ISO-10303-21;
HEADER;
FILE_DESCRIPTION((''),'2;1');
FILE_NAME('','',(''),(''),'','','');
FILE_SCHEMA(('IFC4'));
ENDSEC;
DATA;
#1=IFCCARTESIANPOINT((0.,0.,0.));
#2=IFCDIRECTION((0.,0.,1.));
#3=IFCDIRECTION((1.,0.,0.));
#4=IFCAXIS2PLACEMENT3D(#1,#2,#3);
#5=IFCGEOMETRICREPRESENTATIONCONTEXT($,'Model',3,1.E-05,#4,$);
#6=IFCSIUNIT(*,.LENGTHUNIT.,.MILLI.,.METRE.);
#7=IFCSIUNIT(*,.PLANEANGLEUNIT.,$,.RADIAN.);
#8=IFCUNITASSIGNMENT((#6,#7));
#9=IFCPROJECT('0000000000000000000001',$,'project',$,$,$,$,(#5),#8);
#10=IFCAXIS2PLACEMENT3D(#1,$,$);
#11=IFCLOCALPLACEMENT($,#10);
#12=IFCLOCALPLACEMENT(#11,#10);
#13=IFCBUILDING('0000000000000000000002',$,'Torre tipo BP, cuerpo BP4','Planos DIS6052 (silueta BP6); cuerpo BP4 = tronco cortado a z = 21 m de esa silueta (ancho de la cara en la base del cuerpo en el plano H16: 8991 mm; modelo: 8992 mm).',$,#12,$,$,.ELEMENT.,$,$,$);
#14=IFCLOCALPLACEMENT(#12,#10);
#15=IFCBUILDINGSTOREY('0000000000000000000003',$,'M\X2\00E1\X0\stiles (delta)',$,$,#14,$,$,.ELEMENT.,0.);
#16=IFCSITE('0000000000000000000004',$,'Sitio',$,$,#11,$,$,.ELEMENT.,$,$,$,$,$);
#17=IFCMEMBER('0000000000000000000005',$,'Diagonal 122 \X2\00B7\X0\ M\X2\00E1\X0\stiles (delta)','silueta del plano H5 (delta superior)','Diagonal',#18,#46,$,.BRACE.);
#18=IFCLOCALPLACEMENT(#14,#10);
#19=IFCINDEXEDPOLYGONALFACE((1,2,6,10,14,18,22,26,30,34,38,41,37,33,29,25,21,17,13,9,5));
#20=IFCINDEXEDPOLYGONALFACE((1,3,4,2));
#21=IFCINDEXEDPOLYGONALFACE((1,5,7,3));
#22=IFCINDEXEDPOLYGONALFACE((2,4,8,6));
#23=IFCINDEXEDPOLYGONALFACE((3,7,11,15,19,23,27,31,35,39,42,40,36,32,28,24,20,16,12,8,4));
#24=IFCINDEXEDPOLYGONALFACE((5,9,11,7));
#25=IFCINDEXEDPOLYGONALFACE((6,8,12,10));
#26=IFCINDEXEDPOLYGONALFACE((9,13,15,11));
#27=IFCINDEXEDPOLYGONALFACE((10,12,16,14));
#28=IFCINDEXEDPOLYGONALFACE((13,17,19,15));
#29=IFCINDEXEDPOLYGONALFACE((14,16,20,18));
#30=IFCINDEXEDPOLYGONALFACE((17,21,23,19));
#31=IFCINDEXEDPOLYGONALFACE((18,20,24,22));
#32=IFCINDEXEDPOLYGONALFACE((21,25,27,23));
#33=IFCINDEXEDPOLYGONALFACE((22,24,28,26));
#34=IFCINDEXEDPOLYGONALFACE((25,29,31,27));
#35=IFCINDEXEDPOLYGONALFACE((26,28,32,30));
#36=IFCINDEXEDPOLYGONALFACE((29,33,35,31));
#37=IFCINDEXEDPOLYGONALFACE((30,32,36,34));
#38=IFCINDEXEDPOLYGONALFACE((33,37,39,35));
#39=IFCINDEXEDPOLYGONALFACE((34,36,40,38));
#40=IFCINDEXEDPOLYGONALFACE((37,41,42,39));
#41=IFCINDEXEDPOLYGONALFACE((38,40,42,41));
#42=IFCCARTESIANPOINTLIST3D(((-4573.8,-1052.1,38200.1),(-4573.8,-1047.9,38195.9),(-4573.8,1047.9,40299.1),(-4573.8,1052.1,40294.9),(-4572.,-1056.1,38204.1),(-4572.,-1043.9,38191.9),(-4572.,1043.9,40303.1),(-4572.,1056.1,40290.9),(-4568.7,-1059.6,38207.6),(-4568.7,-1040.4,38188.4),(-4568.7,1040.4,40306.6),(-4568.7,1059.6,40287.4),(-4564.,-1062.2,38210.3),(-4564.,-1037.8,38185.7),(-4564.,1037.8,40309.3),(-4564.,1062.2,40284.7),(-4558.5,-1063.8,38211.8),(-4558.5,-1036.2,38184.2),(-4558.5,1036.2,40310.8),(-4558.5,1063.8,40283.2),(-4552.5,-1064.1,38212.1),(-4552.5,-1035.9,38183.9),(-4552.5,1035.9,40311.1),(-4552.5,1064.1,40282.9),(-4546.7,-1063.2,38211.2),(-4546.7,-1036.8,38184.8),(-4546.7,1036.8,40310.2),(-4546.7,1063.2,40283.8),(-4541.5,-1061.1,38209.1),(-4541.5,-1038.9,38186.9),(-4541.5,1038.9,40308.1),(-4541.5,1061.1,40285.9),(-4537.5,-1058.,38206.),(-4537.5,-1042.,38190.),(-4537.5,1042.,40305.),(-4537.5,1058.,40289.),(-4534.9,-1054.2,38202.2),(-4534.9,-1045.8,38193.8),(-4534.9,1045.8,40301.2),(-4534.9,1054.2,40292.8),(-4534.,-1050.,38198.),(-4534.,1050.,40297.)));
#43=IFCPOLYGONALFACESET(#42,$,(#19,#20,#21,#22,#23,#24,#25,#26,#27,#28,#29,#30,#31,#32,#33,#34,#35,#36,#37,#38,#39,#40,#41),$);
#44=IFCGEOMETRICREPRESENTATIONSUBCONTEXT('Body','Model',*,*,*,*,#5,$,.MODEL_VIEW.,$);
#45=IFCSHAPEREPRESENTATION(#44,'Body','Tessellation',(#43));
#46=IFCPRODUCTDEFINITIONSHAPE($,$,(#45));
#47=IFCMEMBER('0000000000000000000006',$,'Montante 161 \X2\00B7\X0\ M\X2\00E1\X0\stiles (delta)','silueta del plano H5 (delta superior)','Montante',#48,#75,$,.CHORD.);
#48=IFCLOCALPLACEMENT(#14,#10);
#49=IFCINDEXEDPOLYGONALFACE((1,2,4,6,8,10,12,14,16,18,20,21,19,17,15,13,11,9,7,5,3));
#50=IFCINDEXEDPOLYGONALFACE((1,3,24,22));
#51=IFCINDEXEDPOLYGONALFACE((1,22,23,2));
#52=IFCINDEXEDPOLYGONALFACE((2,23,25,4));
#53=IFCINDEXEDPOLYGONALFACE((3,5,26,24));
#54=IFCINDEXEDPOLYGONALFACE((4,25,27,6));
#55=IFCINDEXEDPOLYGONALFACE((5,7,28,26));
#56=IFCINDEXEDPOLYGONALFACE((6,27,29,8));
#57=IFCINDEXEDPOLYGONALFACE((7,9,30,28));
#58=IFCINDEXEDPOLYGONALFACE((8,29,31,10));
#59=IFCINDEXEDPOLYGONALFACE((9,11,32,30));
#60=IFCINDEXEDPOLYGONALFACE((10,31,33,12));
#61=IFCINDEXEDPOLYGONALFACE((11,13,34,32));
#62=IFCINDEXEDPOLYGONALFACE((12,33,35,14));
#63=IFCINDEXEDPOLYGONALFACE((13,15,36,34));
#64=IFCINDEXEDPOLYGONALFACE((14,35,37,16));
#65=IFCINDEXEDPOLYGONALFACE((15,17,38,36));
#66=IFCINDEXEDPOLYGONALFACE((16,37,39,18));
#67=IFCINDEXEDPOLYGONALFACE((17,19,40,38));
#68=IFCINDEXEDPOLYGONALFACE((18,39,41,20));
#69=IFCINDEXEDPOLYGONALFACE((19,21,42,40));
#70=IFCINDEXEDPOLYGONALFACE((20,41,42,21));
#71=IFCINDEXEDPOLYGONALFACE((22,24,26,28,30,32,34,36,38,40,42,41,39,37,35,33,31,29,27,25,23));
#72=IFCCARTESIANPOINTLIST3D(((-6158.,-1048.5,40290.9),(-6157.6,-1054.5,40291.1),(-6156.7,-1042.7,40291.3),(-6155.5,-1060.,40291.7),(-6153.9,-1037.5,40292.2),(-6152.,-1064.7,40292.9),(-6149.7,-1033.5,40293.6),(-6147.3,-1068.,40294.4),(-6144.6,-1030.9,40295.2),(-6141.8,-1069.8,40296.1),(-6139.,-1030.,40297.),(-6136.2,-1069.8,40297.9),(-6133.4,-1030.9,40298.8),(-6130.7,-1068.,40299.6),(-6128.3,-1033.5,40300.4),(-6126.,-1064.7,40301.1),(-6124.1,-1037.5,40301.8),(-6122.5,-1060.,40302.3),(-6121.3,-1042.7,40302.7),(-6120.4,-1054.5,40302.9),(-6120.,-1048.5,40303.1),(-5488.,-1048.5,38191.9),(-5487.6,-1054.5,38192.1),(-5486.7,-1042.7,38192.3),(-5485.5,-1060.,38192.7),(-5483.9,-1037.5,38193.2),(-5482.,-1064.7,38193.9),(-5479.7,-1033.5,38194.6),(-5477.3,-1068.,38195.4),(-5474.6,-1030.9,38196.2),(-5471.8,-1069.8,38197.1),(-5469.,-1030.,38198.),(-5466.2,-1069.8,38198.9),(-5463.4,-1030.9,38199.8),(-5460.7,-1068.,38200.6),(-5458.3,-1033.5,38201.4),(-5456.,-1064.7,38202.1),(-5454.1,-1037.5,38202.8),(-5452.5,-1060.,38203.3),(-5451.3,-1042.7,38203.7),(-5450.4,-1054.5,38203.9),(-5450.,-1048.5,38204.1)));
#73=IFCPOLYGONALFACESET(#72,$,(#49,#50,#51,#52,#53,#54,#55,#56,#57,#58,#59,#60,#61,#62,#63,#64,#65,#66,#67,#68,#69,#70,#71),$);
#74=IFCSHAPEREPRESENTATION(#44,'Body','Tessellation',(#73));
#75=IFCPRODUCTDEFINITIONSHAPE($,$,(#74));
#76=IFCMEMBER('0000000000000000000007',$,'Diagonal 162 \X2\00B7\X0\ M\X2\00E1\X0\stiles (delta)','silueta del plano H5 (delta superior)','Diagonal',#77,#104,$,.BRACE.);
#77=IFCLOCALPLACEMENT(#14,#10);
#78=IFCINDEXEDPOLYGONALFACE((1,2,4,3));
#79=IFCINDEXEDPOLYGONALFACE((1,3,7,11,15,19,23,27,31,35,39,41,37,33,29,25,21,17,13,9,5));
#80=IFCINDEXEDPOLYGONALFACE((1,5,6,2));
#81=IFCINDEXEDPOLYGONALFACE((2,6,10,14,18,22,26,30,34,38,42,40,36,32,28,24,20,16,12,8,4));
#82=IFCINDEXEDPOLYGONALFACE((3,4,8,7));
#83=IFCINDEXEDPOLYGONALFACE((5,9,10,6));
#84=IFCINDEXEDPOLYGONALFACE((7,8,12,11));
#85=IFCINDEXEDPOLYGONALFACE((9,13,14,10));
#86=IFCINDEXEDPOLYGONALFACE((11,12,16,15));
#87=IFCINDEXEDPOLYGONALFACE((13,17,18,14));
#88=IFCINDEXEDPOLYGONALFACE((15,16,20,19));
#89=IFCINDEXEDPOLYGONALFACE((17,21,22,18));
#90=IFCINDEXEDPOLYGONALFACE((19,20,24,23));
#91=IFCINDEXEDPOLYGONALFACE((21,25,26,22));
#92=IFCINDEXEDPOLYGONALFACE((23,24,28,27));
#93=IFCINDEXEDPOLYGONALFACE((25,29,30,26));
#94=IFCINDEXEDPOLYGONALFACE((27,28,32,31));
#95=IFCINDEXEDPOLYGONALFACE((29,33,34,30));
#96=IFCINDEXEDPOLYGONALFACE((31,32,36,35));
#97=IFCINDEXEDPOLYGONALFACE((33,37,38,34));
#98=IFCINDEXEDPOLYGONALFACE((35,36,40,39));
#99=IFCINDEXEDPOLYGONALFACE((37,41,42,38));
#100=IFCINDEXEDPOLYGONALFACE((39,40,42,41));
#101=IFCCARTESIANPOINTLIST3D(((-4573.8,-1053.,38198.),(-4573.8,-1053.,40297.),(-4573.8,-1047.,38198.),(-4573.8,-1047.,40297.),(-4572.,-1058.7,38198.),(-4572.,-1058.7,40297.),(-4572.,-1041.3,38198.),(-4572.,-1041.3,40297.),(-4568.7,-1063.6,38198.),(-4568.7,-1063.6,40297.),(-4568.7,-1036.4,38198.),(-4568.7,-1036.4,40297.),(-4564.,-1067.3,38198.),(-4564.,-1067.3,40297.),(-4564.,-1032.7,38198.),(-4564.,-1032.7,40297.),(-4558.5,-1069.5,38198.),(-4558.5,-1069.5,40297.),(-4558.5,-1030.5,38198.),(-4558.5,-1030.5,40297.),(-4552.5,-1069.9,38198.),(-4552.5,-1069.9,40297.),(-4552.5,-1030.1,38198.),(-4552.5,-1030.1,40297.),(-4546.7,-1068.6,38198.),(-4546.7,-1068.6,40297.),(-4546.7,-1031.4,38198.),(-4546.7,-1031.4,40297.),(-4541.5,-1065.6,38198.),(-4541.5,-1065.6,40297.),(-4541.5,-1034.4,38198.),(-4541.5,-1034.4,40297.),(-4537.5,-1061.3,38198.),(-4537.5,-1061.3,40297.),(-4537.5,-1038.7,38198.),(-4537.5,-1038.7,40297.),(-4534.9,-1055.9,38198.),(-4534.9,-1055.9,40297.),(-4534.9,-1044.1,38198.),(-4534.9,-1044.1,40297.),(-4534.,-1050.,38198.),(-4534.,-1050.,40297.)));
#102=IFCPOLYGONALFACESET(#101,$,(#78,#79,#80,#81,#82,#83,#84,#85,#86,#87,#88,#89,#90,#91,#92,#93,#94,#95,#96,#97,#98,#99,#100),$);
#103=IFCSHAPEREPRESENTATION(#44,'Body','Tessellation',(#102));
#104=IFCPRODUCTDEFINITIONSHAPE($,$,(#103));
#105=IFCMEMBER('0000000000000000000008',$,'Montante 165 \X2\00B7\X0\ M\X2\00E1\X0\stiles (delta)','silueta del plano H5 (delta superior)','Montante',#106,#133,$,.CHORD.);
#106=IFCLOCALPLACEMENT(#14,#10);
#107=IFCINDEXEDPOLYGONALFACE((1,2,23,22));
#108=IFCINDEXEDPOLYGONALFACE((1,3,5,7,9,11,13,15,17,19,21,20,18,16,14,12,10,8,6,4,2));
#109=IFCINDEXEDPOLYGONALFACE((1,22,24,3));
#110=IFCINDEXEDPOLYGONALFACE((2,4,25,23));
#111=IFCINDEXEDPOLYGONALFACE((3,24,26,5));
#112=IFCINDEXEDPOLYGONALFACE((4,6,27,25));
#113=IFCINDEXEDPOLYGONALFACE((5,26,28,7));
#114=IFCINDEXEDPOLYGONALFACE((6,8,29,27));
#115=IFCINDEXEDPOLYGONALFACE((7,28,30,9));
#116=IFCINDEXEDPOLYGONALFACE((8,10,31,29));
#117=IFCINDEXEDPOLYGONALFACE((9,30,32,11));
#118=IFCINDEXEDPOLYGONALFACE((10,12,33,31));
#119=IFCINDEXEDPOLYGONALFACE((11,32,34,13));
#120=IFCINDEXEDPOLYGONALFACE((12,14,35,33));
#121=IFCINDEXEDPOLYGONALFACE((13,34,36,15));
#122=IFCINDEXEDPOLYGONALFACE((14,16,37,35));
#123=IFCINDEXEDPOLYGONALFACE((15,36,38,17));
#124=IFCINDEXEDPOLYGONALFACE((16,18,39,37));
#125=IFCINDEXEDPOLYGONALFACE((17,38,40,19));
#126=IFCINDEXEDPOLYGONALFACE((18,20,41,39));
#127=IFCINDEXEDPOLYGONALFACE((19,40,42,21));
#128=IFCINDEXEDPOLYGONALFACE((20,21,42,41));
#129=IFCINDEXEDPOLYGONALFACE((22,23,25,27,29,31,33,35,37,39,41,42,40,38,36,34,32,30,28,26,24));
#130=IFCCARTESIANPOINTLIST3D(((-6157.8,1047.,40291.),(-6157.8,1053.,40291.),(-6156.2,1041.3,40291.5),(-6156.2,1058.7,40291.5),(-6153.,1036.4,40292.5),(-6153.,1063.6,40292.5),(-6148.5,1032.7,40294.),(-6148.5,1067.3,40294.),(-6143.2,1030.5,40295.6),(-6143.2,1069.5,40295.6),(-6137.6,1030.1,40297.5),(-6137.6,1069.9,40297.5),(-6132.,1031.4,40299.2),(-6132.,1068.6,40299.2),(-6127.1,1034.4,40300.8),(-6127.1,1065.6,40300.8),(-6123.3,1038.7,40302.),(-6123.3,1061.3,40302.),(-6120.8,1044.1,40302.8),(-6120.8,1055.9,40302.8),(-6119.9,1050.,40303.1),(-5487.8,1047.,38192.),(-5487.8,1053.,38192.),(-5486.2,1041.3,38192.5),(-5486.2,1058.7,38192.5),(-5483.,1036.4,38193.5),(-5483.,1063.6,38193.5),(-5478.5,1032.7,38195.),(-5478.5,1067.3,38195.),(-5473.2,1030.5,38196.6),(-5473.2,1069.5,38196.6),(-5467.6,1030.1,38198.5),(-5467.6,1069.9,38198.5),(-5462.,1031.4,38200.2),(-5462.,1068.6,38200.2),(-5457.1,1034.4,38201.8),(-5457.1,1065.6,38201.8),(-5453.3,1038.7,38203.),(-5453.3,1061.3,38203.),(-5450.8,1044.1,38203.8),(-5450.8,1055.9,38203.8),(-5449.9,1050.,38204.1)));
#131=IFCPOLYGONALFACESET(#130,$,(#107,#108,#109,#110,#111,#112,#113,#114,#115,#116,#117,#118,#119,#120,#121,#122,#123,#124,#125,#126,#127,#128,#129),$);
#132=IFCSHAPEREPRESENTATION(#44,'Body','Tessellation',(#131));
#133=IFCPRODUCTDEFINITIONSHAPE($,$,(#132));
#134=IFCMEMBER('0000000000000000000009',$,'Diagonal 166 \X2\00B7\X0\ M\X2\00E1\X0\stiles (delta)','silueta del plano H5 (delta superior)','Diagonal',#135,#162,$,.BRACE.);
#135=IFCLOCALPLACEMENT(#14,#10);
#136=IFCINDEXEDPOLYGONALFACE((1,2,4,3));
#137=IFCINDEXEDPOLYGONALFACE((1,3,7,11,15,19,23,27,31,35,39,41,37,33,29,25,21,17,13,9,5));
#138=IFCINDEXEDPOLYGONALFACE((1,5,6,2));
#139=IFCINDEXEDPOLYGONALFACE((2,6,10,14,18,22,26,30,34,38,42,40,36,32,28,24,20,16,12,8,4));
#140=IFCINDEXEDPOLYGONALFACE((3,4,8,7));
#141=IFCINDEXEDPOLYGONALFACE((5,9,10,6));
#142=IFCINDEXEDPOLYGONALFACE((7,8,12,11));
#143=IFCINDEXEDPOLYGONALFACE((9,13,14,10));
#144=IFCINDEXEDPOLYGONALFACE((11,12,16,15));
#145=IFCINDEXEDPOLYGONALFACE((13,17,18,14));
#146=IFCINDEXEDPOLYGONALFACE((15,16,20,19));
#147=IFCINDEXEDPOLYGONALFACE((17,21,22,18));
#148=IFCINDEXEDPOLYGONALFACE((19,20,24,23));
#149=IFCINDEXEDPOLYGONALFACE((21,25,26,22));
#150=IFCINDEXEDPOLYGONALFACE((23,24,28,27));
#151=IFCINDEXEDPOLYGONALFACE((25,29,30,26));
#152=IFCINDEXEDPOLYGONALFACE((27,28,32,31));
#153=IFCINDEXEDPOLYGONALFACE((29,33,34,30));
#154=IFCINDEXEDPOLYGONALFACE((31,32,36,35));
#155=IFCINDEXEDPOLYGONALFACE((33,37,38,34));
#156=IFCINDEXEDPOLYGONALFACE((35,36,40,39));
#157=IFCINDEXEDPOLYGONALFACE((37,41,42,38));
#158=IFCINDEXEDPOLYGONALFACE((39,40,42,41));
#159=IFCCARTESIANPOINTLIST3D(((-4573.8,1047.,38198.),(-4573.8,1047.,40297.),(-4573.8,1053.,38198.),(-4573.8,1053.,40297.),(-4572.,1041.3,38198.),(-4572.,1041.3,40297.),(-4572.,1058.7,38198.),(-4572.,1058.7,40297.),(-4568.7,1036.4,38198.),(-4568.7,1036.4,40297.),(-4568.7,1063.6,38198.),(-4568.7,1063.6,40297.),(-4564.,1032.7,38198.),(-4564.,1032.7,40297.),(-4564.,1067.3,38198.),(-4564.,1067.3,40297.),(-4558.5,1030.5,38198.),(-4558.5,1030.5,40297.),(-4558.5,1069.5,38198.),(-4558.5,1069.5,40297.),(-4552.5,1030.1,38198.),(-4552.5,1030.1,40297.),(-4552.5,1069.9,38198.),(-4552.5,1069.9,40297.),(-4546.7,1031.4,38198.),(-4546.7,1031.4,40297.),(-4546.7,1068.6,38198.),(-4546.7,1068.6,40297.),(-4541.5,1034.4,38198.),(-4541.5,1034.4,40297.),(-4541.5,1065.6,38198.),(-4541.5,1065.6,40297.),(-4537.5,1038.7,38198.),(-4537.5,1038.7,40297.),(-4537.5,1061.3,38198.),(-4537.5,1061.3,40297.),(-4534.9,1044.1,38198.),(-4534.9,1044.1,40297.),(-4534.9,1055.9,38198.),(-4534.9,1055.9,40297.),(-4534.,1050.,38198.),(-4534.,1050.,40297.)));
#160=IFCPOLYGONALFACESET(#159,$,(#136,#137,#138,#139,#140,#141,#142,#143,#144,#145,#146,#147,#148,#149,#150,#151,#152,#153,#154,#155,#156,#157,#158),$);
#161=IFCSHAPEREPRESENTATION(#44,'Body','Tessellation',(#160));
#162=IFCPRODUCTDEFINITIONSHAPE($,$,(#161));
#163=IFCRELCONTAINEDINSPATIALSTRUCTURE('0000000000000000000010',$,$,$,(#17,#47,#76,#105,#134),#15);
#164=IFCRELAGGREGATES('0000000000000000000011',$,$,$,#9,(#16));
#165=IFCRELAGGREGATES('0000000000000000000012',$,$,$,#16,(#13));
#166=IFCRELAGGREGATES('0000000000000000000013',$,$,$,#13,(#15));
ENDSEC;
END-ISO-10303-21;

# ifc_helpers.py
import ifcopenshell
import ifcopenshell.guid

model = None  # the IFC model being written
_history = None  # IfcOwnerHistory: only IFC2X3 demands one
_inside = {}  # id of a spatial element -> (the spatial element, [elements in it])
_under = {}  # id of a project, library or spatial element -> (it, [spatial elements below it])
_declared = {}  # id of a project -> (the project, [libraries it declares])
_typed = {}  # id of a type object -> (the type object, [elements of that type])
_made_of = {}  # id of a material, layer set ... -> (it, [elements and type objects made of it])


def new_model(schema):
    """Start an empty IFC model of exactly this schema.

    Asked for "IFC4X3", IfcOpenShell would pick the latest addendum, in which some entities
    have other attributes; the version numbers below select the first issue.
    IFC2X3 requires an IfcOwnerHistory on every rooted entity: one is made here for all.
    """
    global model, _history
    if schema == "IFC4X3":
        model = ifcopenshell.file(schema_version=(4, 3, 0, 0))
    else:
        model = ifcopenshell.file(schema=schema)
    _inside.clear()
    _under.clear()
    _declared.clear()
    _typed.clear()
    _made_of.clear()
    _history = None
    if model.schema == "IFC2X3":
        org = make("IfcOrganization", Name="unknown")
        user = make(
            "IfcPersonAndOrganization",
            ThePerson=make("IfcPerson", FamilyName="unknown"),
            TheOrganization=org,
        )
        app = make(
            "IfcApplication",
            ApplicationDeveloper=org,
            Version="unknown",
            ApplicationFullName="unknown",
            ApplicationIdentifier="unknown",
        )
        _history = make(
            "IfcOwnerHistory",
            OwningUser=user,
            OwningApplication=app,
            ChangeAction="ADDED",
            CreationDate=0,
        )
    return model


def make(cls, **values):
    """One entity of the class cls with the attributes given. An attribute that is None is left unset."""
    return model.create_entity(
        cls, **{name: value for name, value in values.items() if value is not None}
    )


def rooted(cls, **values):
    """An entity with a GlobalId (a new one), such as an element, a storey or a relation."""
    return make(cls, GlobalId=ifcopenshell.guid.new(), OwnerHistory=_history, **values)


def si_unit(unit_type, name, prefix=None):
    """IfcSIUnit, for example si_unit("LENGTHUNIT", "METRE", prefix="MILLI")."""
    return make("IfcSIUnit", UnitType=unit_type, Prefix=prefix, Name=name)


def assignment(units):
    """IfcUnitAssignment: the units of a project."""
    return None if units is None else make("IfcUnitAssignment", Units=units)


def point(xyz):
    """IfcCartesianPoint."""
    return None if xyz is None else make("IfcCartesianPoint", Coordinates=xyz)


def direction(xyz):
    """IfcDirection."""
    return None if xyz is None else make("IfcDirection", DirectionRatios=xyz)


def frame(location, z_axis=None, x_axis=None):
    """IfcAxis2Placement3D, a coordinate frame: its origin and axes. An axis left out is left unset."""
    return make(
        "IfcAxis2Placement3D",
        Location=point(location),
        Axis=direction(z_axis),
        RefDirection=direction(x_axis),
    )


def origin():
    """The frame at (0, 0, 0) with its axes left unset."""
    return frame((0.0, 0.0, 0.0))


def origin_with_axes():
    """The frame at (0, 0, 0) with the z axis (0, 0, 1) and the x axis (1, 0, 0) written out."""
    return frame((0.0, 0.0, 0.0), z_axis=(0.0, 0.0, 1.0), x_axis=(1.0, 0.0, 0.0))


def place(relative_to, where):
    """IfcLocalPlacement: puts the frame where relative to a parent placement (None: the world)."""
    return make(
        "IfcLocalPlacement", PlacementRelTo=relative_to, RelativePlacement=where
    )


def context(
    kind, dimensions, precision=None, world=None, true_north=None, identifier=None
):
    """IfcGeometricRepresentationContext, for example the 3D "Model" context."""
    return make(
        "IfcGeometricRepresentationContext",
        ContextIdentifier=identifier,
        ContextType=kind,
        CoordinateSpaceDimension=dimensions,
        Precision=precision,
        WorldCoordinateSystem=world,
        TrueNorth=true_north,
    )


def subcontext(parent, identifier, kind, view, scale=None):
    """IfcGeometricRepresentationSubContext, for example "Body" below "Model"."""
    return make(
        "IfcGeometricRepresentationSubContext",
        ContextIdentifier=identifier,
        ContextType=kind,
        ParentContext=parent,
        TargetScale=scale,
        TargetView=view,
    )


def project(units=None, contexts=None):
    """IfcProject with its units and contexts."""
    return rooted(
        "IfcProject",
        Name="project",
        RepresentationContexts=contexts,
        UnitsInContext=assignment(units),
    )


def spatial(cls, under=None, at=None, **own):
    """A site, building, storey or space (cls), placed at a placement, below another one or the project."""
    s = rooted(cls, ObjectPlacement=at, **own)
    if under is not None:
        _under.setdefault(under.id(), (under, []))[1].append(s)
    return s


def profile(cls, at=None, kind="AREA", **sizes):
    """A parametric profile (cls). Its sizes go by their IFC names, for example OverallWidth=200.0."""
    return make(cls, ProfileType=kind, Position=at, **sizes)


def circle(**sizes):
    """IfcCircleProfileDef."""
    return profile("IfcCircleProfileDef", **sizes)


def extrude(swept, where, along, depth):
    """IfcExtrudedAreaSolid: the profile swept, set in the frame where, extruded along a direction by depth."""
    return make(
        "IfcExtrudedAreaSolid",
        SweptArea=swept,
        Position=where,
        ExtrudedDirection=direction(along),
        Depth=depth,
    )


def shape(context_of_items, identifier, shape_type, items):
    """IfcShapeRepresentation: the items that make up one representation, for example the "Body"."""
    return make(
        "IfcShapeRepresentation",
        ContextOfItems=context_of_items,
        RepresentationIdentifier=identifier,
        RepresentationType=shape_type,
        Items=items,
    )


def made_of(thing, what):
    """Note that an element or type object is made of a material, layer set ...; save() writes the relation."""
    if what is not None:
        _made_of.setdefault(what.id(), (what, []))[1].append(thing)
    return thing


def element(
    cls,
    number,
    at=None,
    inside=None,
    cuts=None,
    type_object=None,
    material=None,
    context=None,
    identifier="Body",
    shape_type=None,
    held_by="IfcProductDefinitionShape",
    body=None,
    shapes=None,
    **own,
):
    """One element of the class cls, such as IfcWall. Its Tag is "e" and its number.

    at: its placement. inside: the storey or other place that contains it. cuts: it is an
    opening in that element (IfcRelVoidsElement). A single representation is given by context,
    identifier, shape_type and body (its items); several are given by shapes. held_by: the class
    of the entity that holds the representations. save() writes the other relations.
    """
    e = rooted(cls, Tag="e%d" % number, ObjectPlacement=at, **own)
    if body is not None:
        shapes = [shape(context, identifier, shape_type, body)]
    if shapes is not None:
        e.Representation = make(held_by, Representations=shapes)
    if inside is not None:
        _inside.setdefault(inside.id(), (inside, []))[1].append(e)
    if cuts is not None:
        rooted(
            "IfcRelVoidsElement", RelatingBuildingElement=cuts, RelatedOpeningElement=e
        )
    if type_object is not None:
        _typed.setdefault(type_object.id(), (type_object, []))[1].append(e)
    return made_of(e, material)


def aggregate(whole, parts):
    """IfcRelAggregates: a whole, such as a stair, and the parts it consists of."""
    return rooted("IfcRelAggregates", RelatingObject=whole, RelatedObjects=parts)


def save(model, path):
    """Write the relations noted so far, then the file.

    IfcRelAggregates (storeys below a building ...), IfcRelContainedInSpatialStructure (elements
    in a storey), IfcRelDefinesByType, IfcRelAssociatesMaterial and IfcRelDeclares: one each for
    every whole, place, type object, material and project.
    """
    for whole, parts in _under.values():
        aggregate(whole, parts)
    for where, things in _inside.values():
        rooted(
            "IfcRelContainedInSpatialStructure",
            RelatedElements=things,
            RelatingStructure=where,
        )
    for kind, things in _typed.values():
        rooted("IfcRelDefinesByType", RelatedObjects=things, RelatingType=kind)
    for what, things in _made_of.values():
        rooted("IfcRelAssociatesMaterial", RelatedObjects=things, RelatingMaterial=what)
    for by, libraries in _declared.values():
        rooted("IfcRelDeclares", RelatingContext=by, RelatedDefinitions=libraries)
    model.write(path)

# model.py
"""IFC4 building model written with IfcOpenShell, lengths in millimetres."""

from ifc_helpers import new_model, si_unit, frame, origin, origin_with_axes, place, context, subcontext, project, spatial, circle, extrude, element, save


model = new_model("IFC4")

# Units and contexts
model_context = context("Model", 3, precision=1e-05, world=origin_with_axes())
body_context = subcontext(model_context, "Body", "Model", "MODEL_VIEW")
ifc_project = project(units=[si_unit("LENGTHUNIT", "METRE", prefix="MILLI"), si_unit("PLANEANGLEUNIT", "RADIAN")], contexts=[model_context])

# Site, building, storey
site_placement = place(None, origin())
site = spatial("IfcSite", under=ifc_project, at=site_placement, Name="Sitio", CompositionType="ELEMENT")
building_placement = place(site_placement, origin())
building = spatial("IfcBuilding", under=site, at=building_placement, Name="Torre tipo BP, cuerpo BP4", Description="Planos DIS6052 (silueta BP6); cuerpo BP4 = tronco cortado a z = 21 m de esa silueta (ancho de la cara en la base del cuerpo en el plano H16: 8991 mm; modelo: 8992 mm).", CompositionType="ELEMENT")
storey_placement = place(building_placement, origin())
storey = spatial("IfcBuildingStorey", under=building, at=storey_placement, Name="Mástiles (delta)", CompositionType="ELEMENT", Elevation=0.0)

# Members
member_1_placement = place(storey_placement, frame((-4554.0, 1050.0, 40297.0), z_axis=(0.0, -0.707275, -0.706938), x_axis=(1.0, 0.0, 0.0)))
element("IfcMember", 1, at=member_1_placement, inside=storey, Name="Diagonal 122 · Mástiles (delta)", Description="silueta del plano H5 (delta superior)", ObjectType="Diagonal", PredefinedType="BRACE", context=body_context, shape_type="SweptSolid", body=[
    extrude(circle(Radius=20.0), None, (0.0, 0.0, 1.0), 2969.1),
])
member_2_placement = place(storey_placement, frame((-6139.0, -1050.0, 40297.0), z_axis=(0.304084, 0.0, -0.952645), x_axis=(0.0, 1.0, 0.0)))
element("IfcMember", 2, at=member_2_placement, inside=storey, Name="Montante 161 · Mástiles (delta)", Description="silueta del plano H5 (delta superior)", ObjectType="Montante", PredefinedType="CHORD", context=body_context, shape_type="SweptSolid", body=[
    extrude(circle(Radius=20.0), None, (0.0, 0.0, 1.0), 2203.3),
])
member_3_placement = place(storey_placement, frame((-4554.0, -1050.0, 40297.0), z_axis=(0.0, 0.0, -1.0), x_axis=(1.0, 0.0, 0.0)))
element("IfcMember", 3, at=member_3_placement, inside=storey, Name="Diagonal 162 · Mástiles (delta)", Description="silueta del plano H5 (delta superior)", ObjectType="Diagonal", PredefinedType="BRACE", context=body_context, shape_type="SweptSolid", body=[
    extrude(circle(Radius=20.0), None, (0.0, 0.0, 1.0), 2099.0),
])
member_4_placement = place(storey_placement, frame((-6139.0, 1050.0, 40297.0), z_axis=(0.304084, 0.0, -0.952645), x_axis=(0.952645, 0.0, 0.304084)))
element("IfcMember", 4, at=member_4_placement, inside=storey, Name="Montante 165 · Mástiles (delta)", Description="silueta del plano H5 (delta superior)", ObjectType="Montante", PredefinedType="CHORD", context=body_context, shape_type="SweptSolid", body=[
    extrude(circle(Radius=20.0), None, (0.0, 0.0, 1.0), 2203.3),
])
member_5_placement = place(storey_placement, frame((-4554.0, 1050.0, 40297.0), z_axis=(0.0, 0.0, -1.0), x_axis=(1.0, 0.0, 0.0)))
element("IfcMember", 5, at=member_5_placement, inside=storey, Name="Diagonal 166 · Mástiles (delta)", Description="silueta del plano H5 (delta superior)", ObjectType="Diagonal", PredefinedType="BRACE", context=body_context, shape_type="SweptSolid", body=[
    extrude(circle(Radius=20.0), None, (0.0, 0.0, 1.0), 2099.0),
])

save(model, "model.ifc")
